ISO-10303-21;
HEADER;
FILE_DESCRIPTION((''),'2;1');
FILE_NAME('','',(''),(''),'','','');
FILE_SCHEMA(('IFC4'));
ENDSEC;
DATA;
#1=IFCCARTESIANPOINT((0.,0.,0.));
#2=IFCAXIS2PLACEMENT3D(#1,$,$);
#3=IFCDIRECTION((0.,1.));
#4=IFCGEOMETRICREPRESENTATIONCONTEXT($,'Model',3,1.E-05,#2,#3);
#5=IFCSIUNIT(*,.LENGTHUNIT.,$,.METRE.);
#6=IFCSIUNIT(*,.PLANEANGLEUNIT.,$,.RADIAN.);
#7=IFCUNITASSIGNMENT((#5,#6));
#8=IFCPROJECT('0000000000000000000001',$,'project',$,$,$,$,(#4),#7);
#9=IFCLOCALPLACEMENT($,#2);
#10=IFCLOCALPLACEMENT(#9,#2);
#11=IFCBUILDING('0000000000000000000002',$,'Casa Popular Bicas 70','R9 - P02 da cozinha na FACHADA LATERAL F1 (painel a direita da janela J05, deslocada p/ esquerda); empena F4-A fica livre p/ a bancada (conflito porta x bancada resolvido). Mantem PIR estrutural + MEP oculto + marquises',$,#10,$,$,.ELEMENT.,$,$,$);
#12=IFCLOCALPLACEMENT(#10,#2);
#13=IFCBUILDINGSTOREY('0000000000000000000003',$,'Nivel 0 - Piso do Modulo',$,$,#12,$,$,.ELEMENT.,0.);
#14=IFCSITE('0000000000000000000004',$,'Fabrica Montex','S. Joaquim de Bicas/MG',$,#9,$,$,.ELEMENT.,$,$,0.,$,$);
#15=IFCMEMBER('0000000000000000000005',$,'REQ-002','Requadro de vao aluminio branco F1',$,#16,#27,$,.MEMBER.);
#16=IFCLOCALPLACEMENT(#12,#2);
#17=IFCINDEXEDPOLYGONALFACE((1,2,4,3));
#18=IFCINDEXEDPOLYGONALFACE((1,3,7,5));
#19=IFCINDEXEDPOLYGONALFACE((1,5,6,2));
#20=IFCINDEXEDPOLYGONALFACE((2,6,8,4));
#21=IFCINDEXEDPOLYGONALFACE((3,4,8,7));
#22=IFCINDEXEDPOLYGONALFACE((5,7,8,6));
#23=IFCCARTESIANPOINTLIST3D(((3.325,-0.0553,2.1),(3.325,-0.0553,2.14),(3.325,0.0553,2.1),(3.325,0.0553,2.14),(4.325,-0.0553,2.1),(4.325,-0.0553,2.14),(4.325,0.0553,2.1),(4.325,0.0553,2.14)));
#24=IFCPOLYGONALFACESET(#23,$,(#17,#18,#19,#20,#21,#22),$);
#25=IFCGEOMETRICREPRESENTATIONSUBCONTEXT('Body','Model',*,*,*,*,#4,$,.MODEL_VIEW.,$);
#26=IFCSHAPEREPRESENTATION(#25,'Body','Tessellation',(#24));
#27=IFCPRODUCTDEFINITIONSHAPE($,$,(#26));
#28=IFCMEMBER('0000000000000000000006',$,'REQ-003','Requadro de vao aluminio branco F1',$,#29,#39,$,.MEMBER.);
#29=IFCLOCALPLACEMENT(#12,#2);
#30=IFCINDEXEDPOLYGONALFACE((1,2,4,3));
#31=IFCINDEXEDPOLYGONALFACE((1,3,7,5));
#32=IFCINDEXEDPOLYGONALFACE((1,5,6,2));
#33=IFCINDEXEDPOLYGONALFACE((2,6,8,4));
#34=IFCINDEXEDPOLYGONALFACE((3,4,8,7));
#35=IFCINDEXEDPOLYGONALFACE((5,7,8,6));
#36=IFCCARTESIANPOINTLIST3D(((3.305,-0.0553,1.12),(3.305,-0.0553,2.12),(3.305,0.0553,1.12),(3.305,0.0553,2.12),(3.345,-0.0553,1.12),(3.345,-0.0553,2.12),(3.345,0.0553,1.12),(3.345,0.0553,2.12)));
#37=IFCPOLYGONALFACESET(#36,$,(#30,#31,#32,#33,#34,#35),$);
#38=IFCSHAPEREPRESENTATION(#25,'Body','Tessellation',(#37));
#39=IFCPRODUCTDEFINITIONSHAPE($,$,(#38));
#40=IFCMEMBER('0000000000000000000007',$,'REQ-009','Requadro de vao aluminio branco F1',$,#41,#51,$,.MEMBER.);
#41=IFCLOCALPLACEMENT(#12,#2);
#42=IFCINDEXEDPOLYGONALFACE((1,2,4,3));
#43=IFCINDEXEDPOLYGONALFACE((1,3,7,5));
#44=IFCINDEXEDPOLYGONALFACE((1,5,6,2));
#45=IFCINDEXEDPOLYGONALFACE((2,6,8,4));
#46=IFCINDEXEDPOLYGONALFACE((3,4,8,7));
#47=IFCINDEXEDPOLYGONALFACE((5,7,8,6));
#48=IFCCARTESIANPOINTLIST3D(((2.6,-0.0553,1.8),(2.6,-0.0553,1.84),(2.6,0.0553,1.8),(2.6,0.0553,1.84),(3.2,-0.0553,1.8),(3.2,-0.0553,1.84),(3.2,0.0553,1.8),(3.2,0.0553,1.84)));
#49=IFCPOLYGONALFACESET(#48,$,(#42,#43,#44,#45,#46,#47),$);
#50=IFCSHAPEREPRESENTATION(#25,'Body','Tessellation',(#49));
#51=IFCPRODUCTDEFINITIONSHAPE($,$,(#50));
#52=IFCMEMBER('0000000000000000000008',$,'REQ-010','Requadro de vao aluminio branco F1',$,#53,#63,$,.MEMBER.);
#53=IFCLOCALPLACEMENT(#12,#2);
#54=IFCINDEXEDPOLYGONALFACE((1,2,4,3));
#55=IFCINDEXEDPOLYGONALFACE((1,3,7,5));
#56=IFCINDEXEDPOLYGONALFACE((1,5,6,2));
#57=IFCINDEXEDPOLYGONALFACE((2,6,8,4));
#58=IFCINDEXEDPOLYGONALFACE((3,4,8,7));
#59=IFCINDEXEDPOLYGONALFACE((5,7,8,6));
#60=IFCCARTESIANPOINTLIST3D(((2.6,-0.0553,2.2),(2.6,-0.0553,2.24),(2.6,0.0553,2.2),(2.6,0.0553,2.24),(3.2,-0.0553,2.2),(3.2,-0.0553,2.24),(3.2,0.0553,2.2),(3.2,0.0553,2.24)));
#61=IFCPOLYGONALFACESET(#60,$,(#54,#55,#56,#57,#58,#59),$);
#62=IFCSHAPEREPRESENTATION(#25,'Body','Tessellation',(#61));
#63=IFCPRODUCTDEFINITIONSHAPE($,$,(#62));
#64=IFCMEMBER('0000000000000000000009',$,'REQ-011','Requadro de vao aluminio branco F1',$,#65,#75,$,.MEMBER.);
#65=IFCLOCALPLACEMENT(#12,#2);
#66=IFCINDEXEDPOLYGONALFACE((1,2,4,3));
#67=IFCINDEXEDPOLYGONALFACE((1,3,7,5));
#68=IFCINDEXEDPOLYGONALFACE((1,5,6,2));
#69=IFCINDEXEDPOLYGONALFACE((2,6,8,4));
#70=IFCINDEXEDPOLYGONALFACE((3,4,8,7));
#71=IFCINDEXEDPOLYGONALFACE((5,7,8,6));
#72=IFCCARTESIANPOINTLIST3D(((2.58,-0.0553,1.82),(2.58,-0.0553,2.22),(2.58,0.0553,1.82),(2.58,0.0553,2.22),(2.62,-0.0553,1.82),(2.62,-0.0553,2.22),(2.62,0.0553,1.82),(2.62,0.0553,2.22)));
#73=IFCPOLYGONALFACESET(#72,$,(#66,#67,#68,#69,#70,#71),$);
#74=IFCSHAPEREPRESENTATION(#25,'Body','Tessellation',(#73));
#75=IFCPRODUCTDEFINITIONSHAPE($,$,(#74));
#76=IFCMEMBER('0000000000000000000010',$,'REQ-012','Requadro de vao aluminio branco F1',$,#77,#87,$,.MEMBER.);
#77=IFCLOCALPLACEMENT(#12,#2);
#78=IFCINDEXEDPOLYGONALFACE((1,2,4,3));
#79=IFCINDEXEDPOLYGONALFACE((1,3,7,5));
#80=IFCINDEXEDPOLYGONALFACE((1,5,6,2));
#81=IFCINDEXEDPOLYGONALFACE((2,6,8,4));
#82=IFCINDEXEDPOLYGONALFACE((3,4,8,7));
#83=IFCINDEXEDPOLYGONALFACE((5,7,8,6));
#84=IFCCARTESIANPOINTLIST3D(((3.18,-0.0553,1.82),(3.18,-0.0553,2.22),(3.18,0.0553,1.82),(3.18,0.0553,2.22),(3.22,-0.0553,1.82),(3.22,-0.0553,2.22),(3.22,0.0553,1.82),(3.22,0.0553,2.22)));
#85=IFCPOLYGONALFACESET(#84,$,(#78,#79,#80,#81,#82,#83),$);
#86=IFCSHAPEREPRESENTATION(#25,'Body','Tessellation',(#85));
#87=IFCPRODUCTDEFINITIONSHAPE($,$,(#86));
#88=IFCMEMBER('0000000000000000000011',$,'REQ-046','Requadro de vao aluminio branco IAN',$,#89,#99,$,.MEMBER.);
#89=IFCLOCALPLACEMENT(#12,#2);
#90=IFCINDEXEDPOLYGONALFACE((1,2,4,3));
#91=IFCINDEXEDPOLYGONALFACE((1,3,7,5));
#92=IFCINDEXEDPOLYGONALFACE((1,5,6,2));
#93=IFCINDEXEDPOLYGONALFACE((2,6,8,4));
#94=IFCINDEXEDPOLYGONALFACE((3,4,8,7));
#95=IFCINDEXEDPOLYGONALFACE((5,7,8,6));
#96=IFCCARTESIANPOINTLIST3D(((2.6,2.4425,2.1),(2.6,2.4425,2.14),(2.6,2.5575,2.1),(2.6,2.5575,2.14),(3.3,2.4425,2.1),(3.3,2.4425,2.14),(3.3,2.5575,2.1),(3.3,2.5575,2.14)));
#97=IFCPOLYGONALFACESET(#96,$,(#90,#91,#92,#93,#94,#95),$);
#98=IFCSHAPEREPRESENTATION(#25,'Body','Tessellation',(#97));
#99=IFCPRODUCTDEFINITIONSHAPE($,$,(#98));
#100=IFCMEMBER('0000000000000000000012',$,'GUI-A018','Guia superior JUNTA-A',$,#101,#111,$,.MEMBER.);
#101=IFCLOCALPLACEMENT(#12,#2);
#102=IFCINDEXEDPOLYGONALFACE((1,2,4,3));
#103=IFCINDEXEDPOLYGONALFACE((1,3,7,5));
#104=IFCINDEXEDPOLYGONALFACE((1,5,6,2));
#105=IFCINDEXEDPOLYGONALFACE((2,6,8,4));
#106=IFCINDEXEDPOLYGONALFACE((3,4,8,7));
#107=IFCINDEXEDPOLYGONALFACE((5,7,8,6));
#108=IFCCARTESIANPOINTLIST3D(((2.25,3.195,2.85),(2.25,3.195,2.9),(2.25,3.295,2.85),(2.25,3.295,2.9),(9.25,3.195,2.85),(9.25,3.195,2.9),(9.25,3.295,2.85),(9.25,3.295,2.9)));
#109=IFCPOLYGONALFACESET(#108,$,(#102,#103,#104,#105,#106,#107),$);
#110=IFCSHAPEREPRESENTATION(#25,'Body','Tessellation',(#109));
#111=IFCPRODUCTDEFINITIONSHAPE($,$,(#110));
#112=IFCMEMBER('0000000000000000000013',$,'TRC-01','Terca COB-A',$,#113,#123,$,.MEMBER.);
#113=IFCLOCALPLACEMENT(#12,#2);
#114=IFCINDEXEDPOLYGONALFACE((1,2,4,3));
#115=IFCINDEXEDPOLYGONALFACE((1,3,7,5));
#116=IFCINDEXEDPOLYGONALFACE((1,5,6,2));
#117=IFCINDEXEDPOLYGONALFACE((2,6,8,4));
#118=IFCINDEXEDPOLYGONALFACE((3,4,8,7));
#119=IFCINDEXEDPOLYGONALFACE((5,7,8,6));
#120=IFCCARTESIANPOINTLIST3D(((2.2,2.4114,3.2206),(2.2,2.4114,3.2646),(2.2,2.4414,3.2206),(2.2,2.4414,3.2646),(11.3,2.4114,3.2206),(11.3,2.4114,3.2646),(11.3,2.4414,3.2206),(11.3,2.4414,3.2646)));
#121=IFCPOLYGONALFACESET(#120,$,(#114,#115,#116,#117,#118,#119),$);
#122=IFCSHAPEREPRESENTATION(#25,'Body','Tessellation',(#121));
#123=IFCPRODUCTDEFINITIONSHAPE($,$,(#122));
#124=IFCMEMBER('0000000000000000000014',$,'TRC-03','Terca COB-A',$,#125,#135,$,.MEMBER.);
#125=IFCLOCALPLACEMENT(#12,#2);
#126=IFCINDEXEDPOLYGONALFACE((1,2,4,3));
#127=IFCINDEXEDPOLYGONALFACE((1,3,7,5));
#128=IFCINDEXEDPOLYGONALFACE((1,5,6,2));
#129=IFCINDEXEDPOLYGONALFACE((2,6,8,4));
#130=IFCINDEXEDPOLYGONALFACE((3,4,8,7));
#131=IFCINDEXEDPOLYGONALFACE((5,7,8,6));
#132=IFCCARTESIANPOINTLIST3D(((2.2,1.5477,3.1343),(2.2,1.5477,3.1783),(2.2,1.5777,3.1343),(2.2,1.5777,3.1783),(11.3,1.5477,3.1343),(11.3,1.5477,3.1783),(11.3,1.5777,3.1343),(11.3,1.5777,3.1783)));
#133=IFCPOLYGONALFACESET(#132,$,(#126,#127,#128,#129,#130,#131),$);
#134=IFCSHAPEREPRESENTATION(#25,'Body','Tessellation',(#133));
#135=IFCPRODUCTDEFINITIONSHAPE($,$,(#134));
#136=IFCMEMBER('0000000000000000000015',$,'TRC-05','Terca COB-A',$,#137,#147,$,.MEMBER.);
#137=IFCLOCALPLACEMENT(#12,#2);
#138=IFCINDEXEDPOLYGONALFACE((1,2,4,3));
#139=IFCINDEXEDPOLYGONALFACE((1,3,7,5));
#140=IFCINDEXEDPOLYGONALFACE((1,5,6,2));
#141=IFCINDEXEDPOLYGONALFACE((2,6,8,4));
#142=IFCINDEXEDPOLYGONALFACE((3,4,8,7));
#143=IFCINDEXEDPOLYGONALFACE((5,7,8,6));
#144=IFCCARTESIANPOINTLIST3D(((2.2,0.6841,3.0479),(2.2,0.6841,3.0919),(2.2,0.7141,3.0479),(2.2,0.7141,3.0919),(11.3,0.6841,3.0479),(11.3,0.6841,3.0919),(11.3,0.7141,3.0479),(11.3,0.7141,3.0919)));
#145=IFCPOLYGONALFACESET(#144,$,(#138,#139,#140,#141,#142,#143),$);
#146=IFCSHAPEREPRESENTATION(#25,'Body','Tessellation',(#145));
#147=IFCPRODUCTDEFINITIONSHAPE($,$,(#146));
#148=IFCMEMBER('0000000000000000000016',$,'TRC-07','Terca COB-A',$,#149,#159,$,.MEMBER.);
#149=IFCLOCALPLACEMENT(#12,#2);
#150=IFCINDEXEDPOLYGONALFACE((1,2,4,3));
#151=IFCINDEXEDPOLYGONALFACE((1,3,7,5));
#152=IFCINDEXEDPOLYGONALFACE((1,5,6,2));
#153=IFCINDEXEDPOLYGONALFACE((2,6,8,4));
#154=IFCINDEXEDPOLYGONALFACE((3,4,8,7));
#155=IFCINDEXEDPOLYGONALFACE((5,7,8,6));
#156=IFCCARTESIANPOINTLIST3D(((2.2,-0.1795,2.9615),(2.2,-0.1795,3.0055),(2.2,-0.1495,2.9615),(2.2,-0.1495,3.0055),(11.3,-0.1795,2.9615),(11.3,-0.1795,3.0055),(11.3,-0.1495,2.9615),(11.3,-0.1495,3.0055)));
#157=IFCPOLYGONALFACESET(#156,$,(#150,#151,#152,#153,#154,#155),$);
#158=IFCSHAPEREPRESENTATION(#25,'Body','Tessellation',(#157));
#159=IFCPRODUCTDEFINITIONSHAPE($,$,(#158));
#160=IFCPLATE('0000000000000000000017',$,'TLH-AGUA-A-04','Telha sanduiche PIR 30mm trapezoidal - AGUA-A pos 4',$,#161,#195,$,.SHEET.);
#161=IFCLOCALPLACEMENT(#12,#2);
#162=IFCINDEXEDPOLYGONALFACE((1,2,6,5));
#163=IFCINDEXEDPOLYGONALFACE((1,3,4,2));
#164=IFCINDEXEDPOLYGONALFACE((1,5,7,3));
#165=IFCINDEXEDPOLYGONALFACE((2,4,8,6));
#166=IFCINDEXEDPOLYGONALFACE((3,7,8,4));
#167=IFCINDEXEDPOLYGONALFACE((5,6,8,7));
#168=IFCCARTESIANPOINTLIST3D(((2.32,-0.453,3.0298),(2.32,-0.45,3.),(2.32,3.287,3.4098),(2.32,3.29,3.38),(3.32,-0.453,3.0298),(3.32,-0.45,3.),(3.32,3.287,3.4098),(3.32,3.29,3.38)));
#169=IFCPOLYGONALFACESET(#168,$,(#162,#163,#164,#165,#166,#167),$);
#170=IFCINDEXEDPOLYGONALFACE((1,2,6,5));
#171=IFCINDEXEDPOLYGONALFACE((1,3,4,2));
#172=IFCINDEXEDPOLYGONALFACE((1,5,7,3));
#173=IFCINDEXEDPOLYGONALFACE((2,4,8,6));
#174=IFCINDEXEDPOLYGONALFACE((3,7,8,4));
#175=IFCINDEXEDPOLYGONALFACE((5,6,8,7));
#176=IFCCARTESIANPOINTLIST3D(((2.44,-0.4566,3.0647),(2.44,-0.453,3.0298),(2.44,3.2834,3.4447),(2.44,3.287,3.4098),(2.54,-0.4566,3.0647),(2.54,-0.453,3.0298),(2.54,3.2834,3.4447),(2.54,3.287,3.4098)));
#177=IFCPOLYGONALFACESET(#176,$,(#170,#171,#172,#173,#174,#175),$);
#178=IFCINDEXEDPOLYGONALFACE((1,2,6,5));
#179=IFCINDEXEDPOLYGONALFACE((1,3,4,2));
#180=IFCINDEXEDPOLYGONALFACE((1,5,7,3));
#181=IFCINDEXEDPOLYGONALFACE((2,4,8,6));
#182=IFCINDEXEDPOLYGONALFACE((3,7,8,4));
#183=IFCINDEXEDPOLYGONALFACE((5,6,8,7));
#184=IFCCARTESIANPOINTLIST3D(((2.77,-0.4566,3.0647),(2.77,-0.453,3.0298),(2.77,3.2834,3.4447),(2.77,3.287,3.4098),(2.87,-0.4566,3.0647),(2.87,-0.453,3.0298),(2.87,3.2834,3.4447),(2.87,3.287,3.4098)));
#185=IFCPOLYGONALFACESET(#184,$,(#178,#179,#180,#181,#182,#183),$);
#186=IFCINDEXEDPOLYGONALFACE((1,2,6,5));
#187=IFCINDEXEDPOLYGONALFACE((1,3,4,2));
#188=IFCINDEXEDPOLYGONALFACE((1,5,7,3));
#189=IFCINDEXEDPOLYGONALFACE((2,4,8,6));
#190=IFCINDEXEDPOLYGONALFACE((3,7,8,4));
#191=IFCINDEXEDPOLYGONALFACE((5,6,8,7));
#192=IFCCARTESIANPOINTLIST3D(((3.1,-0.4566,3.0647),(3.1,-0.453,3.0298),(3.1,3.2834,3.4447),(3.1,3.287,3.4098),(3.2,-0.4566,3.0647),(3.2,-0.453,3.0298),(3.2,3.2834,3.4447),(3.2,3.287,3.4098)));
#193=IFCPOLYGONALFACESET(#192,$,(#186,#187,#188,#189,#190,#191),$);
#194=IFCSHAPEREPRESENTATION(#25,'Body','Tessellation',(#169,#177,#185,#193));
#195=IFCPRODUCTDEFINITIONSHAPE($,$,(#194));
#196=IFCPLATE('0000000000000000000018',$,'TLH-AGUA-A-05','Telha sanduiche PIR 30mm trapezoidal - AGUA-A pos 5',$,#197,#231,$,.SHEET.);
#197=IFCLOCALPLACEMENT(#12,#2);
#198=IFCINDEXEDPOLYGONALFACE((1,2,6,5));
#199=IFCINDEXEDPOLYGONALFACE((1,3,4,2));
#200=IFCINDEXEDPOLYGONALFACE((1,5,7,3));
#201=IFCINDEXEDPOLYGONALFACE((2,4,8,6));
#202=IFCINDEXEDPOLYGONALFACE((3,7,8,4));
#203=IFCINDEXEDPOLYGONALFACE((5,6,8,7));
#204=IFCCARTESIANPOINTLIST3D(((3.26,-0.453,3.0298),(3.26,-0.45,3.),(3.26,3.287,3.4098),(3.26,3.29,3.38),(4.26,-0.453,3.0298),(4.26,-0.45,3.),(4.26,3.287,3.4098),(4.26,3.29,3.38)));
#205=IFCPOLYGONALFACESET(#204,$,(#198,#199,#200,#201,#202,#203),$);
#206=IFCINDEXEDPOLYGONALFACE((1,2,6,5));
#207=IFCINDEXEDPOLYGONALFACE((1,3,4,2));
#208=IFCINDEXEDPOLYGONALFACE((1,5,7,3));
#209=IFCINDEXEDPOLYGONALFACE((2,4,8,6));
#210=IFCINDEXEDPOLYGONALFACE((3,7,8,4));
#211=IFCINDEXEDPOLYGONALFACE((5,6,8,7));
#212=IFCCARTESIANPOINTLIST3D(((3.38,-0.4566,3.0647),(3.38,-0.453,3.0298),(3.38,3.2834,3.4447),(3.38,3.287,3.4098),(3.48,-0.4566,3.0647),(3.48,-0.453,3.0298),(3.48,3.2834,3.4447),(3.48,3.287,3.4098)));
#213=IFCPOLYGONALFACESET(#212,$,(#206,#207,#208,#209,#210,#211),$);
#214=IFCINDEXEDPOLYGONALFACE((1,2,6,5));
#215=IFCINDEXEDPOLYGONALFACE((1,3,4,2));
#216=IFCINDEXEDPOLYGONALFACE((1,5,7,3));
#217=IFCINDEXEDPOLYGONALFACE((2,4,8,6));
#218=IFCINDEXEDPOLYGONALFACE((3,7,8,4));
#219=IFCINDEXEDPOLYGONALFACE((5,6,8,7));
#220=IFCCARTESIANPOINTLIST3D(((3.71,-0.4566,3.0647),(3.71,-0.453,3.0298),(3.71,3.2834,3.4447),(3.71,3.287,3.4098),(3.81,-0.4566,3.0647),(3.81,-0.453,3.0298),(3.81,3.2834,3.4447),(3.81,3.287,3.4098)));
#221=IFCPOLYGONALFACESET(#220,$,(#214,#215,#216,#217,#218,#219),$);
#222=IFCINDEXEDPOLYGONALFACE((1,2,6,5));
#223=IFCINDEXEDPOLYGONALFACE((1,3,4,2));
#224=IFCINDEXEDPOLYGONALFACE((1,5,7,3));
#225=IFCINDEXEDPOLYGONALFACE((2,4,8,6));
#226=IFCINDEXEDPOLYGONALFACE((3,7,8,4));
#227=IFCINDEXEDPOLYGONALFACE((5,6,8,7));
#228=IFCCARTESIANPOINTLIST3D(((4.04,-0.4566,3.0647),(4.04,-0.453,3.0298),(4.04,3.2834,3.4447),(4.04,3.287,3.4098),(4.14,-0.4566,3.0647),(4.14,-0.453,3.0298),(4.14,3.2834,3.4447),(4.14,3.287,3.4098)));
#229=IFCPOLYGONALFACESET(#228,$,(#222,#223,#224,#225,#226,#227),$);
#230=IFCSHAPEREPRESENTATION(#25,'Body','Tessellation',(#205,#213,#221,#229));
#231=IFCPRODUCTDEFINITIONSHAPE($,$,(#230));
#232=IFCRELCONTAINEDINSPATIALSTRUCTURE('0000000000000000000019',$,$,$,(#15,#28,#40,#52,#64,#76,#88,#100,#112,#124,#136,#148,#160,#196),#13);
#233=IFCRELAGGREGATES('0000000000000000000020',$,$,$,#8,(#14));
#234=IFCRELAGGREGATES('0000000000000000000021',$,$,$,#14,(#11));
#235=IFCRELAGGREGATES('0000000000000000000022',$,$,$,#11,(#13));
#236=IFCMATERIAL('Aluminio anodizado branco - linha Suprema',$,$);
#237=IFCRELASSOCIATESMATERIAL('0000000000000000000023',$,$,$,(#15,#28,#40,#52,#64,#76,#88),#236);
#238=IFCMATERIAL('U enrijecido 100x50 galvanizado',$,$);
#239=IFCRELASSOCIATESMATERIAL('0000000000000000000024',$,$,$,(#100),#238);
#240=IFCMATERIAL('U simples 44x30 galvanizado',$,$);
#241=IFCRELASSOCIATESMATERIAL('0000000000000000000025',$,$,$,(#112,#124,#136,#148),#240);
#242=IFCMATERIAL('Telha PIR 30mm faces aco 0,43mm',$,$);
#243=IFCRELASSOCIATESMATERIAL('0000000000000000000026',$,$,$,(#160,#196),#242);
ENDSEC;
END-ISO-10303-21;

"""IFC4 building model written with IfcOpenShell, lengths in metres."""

from ifc_helpers import new_model, si_unit, direction, frame, frame_2d, origin, origin_2d, place, context, subcontext, project, spatial, rectangle, extrude, material, element, save


model = new_model("IFC4")

# Units and contexts
model_context = context("Model", 3, precision=1e-05, world=origin(), true_north=direction((0.0, 1.0)))
body_context = subcontext(model_context, "Body", "Model", "MODEL_VIEW")
ifc_project = project(units=[si_unit("LENGTHUNIT", "METRE"), si_unit("PLANEANGLEUNIT", "RADIAN")], contexts=[model_context])

# Site, building, storey
site_placement = place(None, origin())
site = spatial("IfcSite", under=ifc_project, at=site_placement, Name="Fabrica Montex", Description="S. Joaquim de Bicas/MG", CompositionType="ELEMENT", RefElevation=0.0)
building_placement = place(site_placement, origin())
building = spatial("IfcBuilding", under=site, at=building_placement, Name="Casa Popular Bicas 70", Description="R9 - P02 da cozinha na FACHADA LATERAL F1 (painel a direita da janela J05, deslocada p/ esquerda); empena F4-A fica livre p/ a bancada (conflito porta x bancada resolvido). Mantem PIR estrutural + MEP oculto + marquises", CompositionType="ELEMENT")
storey_placement = place(building_placement, origin())
storey = spatial("IfcBuildingStorey", under=building, at=storey_placement, Name="Nivel 0 - Piso do Modulo", CompositionType="ELEMENT", Elevation=0.0)

# Members
ifc_material_1 = material(Name="Aluminio anodizado branco - linha Suprema")
for number, where, z_axis, x_axis, name in (
    (1, (3.325, 0.0, 2.12), (1.0, 0.0, 0.0), (0.0, 0.0, 1.0), "REQ-002"),
    (2, (3.325, 0.0, 1.12), (0.0, 0.0, 1.0), (1.0, 0.0, 0.0), "REQ-003"),
):
    element("IfcMember", number, at=place(storey_placement, frame(where, z_axis=z_axis, x_axis=x_axis)), inside=storey, material=ifc_material_1, Name=name, Description="Requadro de vao aluminio branco F1", PredefinedType="MEMBER", context=body_context, shape_type="SweptSolid", body=[
        extrude(rectangle(XDim=0.04, YDim=0.1105, at=origin_2d()), origin(), (0.0, 0.0, 1.0), 1.0),
    ])
for number, where, z_axis, x_axis, name in (
    (3, (2.6, 0.0, 1.82), (1.0, 0.0, 0.0), (0.0, 0.0, 1.0), "REQ-009"),
    (4, (2.6, 0.0, 2.22), (1.0, 0.0, 0.0), (0.0, 0.0, 1.0), "REQ-010"),
):
    element("IfcMember", number, at=place(storey_placement, frame(where, z_axis=z_axis, x_axis=x_axis)), inside=storey, material=ifc_material_1, Name=name, Description="Requadro de vao aluminio branco F1", PredefinedType="MEMBER", context=body_context, shape_type="SweptSolid", body=[
        extrude(rectangle(XDim=0.04, YDim=0.1105, at=origin_2d()), origin(), (0.0, 0.0, 1.0), 0.6),
    ])
for number, where, z_axis, x_axis, name in (
    (5, (2.6, 0.0, 1.82), (0.0, 0.0, 1.0), (1.0, 0.0, 0.0), "REQ-011"),
    (6, (3.2, 0.0, 1.82), (0.0, 0.0, 1.0), (1.0, 0.0, 0.0), "REQ-012"),
):
    element("IfcMember", number, at=place(storey_placement, frame(where, z_axis=z_axis, x_axis=x_axis)), inside=storey, material=ifc_material_1, Name=name, Description="Requadro de vao aluminio branco F1", PredefinedType="MEMBER", context=body_context, shape_type="SweptSolid", body=[
        extrude(rectangle(XDim=0.04, YDim=0.1105, at=origin_2d()), origin(), (0.0, 0.0, 1.0), 0.4),
    ])
member_1_placement = place(storey_placement, frame((2.6, 2.5, 2.12), z_axis=(1.0, 0.0, 0.0), x_axis=(0.0, 0.0, 1.0)))
element("IfcMember", 7, at=member_1_placement, inside=storey, material=ifc_material_1, Name="REQ-046", Description="Requadro de vao aluminio branco IAN", PredefinedType="MEMBER", context=body_context, shape_type="SweptSolid", body=[
    extrude(rectangle(XDim=0.04, YDim=0.115, at=origin_2d()), origin(), (0.0, 0.0, 1.0), 0.7),
])
ifc_material_2 = material(Name="U enrijecido 100x50 galvanizado")
member_2_placement = place(storey_placement, frame((2.25, 3.245, 2.875), z_axis=(1.0, 0.0, 0.0), x_axis=(0.0, 0.0, 1.0)))
element("IfcMember", 8, at=member_2_placement, inside=storey, material=ifc_material_2, Name="GUI-A018", Description="Guia superior JUNTA-A", PredefinedType="MEMBER", context=body_context, shape_type="SweptSolid", body=[
    extrude(rectangle(XDim=0.05, YDim=0.1, at=origin_2d()), origin(), (0.0, 0.0, 1.0), 7.0),
])
ifc_material_3 = material(Name="U simples 44x30 galvanizado")
for number, where, z_axis, x_axis, name in (
    (9, (2.2, 2.4264, 3.2426), (1.0, 0.0, 0.0), (0.0, 0.0, 1.0), "TRC-01"),
    (10, (2.2, 1.5627, 3.1563), (1.0, 0.0, 0.0), (0.0, 0.0, 1.0), "TRC-03"),
    (11, (2.2, 0.6991, 3.0699), (1.0, 0.0, 0.0), (0.0, 0.0, 1.0), "TRC-05"),
    (12, (2.2, -0.1645, 2.9835), (1.0, 0.0, 0.0), (0.0, 0.0, 1.0), "TRC-07"),
):
    element("IfcMember", number, at=place(storey_placement, frame(where, z_axis=z_axis, x_axis=x_axis)), inside=storey, material=ifc_material_3, Name=name, Description="Terca COB-A", PredefinedType="MEMBER", context=body_context, shape_type="SweptSolid", body=[
        extrude(rectangle(XDim=0.044, YDim=0.03, at=origin_2d()), origin(), (0.0, 0.0, 1.0), 9.1),
    ])

# Plates
ifc_material_4 = material(Name="Telha PIR 30mm faces aco 0,43mm")
for number, where, z_axis, x_axis, name, description in (
    (13, (2.32, -0.45, 3.0), (0.0, -0.101084, 0.994878), (1.0, 0.0, 0.0), "TLH-AGUA-A-04", "Telha sanduiche PIR 30mm trapezoidal - AGUA-A pos 4"),
    (14, (3.26, -0.45, 3.0), (0.0, -0.101084, 0.994878), (1.0, 0.0, 0.0), "TLH-AGUA-A-05", "Telha sanduiche PIR 30mm trapezoidal - AGUA-A pos 5"),
):
    element("IfcPlate", number, at=place(storey_placement, frame(where, z_axis=z_axis, x_axis=x_axis)), inside=storey, material=ifc_material_4, Name=name, Description=description, PredefinedType="SHEET", context=body_context, shape_type="SweptSolid", body=[
        extrude(rectangle(XDim=1.0, YDim=3.7593, at=frame_2d((0.5, 1.8796))), origin(), (0.0, 0.0, 1.0), 0.03),
        extrude(rectangle(XDim=0.1, YDim=3.7593, at=frame_2d((0.17, 1.8796))), frame((0.0, 0.0, 0.03)), (0.0, 0.0, 1.0), 0.035),
        extrude(rectangle(XDim=0.1, YDim=3.7593, at=frame_2d((0.5, 1.8796))), frame((0.0, 0.0, 0.03)), (0.0, 0.0, 1.0), 0.035),
        extrude(rectangle(XDim=0.1, YDim=3.7593, at=frame_2d((0.83, 1.8796))), frame((0.0, 0.0, 0.03)), (0.0, 0.0, 1.0), 0.035),
    ])

save(model, "model.ifc")
